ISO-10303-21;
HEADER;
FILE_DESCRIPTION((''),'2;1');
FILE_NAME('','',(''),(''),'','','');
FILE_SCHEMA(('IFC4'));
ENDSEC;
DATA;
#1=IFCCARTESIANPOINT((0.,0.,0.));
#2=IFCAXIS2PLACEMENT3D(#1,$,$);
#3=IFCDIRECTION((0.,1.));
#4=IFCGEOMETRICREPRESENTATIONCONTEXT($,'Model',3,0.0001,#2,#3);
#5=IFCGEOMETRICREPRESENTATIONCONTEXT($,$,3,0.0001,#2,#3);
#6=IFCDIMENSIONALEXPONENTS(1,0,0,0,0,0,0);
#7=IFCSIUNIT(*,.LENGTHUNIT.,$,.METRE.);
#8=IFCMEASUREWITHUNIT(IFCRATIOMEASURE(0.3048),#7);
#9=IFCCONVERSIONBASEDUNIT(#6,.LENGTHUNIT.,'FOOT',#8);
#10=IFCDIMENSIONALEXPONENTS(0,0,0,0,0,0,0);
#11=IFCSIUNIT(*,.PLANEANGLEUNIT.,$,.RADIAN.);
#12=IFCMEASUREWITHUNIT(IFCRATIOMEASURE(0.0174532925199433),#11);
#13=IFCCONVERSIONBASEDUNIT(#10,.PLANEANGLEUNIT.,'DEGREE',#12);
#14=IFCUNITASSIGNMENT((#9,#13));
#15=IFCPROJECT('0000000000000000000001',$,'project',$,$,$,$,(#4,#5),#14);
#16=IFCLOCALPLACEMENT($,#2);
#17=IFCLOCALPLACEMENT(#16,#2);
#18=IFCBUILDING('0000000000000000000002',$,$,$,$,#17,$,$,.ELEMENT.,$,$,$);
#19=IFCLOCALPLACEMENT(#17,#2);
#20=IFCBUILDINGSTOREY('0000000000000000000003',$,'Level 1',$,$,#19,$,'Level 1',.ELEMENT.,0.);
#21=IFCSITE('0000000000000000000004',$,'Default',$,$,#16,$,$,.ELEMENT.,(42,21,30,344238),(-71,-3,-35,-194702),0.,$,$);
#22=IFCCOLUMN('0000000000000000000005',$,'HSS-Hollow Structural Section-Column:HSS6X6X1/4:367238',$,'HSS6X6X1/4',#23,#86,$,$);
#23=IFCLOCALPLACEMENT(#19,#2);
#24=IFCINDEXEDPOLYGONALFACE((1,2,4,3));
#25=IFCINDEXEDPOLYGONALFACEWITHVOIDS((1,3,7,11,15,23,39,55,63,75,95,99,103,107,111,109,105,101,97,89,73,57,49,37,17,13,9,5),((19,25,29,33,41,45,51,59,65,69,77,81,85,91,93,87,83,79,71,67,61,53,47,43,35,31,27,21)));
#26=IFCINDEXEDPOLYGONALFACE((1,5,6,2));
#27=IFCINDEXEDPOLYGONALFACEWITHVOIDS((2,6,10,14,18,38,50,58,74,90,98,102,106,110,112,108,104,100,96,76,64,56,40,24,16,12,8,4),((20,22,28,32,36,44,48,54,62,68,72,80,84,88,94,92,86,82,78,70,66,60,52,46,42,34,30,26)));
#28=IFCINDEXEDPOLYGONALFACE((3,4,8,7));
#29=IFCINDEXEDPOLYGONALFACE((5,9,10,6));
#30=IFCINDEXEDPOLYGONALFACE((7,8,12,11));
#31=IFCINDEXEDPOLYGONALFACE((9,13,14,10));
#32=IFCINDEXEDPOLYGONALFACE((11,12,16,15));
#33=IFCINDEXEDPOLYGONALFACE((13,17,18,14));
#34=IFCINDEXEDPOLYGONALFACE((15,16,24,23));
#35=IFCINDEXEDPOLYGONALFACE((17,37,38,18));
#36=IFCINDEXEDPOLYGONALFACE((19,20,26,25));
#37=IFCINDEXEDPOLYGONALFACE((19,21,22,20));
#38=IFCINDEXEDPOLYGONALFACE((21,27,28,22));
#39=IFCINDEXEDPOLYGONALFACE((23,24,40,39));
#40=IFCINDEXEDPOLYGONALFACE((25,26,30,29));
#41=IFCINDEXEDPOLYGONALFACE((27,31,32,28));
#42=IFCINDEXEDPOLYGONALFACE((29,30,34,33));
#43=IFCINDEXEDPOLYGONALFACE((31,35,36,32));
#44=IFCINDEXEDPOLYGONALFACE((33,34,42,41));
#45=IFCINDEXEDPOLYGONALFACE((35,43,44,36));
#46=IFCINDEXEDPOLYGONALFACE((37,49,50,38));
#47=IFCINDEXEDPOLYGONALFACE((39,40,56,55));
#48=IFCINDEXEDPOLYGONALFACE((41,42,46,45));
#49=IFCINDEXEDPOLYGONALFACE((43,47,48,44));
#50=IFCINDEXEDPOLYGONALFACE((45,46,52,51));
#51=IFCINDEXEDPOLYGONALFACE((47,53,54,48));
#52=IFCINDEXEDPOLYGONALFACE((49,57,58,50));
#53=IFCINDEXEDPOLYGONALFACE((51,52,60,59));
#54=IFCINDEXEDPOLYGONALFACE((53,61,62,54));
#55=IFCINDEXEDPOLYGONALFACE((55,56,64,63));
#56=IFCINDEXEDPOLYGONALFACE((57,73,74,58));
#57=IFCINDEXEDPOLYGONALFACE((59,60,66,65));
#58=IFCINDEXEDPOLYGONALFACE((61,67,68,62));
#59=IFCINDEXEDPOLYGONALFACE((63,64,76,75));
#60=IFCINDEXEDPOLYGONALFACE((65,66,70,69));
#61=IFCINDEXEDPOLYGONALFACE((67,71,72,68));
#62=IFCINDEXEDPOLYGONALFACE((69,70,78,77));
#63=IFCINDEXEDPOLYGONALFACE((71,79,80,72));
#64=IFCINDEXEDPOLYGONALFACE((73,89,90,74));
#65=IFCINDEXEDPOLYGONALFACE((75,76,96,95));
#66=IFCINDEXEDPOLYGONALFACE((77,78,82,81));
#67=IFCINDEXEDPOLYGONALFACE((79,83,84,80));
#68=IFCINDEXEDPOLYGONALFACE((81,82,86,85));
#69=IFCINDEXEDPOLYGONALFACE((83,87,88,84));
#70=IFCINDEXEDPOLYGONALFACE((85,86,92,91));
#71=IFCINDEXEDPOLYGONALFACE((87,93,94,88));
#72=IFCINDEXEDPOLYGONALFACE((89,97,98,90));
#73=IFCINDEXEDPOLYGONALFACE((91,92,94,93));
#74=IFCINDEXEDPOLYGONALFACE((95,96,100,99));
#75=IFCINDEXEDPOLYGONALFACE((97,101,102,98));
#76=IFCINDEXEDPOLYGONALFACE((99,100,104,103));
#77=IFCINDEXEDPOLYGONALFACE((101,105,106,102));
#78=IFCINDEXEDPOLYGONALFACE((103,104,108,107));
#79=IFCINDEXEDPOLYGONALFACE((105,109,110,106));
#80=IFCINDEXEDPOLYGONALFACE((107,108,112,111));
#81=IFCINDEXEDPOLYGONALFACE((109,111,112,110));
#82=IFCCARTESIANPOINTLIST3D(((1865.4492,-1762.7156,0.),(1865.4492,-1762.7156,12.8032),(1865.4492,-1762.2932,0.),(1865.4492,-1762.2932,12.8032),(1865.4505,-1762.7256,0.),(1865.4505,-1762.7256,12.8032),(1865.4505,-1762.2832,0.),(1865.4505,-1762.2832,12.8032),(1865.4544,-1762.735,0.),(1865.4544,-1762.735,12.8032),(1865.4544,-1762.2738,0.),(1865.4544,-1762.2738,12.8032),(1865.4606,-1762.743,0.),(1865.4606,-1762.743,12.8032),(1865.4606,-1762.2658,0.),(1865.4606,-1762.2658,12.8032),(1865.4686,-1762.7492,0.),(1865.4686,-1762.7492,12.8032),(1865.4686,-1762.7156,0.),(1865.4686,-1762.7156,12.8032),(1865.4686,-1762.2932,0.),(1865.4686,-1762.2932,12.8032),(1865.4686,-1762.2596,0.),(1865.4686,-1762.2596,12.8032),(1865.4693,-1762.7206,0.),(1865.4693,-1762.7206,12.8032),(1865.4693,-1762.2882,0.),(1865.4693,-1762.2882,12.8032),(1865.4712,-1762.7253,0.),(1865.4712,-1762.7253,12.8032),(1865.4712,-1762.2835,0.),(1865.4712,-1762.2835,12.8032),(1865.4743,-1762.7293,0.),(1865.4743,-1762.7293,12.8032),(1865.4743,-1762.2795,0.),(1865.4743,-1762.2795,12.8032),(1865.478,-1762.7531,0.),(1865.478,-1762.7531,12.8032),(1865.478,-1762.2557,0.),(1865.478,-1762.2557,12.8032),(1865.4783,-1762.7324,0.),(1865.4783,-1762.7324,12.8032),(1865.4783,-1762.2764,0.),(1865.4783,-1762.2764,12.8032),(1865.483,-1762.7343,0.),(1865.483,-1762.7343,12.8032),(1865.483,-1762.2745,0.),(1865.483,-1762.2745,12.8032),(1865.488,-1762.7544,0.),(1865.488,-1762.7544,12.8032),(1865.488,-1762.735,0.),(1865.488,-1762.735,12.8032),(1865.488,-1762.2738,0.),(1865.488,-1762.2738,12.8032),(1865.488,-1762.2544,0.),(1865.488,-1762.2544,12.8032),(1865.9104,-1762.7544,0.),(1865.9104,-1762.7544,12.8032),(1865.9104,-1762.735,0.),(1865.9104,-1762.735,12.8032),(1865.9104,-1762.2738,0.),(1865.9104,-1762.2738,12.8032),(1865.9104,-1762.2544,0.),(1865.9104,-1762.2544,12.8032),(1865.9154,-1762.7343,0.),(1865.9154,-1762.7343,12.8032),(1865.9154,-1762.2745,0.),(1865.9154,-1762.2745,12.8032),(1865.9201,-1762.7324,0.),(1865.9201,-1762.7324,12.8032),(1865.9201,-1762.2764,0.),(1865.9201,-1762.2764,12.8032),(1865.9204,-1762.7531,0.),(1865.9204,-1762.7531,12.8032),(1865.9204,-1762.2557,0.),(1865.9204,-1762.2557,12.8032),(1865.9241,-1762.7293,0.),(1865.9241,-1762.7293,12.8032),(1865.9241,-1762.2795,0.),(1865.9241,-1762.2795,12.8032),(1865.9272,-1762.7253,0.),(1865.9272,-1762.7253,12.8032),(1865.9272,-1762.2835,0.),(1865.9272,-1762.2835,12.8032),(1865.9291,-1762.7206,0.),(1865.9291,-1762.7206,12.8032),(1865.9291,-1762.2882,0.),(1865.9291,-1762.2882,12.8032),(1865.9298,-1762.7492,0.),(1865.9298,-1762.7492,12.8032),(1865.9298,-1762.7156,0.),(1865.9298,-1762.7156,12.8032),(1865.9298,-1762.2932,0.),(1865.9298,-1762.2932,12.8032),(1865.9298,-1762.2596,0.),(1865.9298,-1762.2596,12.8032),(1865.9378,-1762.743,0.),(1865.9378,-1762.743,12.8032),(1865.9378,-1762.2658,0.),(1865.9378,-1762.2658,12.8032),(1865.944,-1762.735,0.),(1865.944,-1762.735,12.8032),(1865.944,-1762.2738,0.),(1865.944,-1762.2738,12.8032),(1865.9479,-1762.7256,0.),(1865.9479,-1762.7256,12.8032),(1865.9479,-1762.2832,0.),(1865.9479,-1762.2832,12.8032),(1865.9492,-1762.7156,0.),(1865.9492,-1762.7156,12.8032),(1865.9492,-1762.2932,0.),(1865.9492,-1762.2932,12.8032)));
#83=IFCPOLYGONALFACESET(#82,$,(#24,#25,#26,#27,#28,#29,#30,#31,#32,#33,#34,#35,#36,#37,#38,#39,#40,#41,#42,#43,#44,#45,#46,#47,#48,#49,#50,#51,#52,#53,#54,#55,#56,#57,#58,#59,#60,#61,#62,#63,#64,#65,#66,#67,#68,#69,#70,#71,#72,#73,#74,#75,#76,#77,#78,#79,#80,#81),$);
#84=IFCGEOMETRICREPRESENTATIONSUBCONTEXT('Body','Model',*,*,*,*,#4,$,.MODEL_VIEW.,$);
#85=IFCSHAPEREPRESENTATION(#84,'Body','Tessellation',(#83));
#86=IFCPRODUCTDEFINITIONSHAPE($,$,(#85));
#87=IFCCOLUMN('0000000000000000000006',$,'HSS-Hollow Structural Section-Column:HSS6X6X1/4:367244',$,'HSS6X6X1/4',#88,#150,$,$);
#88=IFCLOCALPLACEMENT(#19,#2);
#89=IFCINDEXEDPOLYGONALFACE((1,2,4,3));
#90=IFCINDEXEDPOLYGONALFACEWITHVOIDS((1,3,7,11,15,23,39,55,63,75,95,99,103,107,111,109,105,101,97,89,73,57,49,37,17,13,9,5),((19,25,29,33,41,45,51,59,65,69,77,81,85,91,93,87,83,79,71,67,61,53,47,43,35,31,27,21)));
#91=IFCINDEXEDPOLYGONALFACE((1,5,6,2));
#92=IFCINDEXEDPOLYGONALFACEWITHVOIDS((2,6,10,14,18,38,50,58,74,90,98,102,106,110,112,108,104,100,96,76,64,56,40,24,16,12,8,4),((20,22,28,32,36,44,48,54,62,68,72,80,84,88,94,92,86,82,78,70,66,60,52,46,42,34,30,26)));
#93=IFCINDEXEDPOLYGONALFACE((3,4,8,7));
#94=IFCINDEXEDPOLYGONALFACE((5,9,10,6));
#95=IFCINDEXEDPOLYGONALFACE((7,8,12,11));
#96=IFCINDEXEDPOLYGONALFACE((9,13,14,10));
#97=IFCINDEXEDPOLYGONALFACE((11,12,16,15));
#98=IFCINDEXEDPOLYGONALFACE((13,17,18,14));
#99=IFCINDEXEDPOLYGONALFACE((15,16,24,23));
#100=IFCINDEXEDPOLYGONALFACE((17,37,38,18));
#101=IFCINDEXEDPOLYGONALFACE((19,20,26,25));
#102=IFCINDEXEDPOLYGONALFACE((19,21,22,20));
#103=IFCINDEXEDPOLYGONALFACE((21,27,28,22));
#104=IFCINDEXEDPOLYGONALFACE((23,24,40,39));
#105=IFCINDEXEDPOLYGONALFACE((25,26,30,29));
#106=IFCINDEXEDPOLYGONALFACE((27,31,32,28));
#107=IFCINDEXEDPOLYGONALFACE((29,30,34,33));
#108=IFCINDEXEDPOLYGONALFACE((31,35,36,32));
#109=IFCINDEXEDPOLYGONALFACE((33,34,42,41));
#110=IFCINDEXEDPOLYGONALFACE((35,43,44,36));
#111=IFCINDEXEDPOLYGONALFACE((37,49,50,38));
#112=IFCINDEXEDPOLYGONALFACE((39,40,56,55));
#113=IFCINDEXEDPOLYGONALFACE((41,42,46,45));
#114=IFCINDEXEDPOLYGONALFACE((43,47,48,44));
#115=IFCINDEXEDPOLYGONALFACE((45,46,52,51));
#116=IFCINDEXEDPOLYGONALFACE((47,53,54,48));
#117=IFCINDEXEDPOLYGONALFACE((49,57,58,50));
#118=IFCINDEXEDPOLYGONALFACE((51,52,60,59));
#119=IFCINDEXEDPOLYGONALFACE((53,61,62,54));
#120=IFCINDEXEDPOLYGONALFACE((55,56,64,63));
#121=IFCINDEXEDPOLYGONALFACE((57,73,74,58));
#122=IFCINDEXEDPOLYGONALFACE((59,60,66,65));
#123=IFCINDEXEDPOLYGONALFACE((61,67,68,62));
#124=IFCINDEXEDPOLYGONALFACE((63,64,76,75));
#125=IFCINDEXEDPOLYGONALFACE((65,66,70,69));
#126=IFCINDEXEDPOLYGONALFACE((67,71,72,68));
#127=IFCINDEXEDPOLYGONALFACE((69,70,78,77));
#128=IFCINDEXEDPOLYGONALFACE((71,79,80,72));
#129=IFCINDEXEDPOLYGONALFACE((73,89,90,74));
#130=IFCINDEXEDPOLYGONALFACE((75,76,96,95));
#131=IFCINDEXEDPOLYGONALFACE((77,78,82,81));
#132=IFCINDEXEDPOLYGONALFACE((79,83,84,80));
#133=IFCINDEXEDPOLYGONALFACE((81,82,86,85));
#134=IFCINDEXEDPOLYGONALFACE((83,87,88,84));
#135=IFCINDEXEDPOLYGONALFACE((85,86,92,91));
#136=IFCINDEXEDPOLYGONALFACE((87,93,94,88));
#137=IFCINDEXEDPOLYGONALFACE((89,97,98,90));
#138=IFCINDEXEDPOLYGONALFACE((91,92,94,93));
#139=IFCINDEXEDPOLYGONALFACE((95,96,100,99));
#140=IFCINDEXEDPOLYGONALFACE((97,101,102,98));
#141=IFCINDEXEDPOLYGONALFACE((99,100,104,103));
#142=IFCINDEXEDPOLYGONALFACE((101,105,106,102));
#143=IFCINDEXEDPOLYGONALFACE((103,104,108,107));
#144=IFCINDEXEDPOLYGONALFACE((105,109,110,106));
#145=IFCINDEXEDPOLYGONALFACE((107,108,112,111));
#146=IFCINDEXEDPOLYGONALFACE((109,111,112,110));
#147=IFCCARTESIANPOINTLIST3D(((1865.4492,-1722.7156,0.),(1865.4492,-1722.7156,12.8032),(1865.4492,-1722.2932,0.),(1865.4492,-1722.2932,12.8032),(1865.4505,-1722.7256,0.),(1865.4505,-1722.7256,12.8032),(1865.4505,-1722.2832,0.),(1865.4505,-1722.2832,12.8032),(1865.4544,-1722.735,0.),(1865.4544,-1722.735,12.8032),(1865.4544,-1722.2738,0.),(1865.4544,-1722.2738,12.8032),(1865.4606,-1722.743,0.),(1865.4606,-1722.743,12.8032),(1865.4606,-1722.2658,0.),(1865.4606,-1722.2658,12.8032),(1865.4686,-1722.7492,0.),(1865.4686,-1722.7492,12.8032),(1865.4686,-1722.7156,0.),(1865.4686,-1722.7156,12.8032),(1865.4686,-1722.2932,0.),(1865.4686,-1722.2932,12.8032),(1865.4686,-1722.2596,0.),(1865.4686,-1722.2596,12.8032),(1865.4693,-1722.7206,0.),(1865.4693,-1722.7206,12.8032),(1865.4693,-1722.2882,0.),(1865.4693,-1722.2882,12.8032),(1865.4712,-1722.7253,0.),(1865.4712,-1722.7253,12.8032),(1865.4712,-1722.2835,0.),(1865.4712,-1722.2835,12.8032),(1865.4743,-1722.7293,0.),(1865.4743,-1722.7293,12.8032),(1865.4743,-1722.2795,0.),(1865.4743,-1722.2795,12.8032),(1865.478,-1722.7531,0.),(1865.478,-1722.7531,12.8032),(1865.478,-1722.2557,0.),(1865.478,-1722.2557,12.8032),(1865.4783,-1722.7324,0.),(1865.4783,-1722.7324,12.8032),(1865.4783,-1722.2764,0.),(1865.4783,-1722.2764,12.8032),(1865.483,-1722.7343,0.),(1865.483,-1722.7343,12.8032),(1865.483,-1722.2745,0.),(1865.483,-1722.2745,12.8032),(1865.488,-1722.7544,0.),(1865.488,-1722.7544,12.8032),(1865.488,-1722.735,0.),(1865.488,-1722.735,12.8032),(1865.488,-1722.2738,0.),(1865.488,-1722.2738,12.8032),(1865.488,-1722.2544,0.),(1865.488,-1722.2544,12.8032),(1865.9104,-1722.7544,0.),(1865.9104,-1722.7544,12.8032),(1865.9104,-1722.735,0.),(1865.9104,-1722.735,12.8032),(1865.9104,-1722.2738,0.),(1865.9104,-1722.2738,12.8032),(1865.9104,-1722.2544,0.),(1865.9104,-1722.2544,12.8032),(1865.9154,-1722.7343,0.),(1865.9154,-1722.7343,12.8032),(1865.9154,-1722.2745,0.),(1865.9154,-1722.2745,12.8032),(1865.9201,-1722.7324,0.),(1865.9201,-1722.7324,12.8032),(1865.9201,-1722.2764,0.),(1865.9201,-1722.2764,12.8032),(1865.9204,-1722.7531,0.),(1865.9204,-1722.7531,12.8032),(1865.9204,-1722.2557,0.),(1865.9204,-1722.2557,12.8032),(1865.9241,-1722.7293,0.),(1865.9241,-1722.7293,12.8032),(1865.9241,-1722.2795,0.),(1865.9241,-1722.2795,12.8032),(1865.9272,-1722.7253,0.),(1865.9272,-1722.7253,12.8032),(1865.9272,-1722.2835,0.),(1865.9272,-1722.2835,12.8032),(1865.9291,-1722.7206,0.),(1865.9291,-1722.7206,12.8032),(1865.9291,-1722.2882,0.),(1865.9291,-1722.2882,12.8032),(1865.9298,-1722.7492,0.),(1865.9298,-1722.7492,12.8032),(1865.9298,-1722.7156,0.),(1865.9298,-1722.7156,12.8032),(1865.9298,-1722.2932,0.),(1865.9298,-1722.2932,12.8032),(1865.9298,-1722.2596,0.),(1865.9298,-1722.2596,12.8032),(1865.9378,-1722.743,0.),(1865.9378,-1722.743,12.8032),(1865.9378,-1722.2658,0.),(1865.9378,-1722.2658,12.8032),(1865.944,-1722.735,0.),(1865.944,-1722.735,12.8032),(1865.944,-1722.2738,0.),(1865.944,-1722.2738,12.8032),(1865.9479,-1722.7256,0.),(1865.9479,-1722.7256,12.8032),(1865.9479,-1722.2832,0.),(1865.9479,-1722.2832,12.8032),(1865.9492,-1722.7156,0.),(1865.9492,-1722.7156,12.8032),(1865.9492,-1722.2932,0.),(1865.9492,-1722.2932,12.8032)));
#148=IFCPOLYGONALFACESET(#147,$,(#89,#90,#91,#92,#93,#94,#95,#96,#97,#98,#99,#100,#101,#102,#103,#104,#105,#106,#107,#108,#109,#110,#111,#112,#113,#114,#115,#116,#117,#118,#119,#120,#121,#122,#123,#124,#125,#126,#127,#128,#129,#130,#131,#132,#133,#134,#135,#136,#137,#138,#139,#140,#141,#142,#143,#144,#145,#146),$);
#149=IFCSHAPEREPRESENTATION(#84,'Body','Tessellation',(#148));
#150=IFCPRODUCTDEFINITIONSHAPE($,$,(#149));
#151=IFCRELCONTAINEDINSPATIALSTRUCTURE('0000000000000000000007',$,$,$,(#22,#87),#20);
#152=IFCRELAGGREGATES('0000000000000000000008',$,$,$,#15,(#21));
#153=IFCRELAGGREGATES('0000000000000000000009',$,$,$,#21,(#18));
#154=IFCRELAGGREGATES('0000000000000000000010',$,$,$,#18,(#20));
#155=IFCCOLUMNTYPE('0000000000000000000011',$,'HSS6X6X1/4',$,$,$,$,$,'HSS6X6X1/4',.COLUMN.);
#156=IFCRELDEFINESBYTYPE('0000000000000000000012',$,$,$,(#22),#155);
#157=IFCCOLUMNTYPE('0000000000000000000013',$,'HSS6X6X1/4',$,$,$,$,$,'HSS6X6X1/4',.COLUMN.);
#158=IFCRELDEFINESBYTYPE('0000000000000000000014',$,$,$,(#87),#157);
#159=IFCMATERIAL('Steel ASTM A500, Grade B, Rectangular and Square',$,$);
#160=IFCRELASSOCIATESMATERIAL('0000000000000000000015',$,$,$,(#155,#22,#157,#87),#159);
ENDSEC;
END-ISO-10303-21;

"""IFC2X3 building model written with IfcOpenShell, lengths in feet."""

from ifc_helpers import new_model, entity, si_unit, converted_unit, direction, frame, frame_2d, origin, place, context, subcontext, project, spatial, polyline, circle_curve, parameter, trimmed, segment, composite_curve, outline, extrude, source, transform, mapped, material, type_object, type_shapes, element, save


model = new_model("IFC2X3")

# Units and contexts
model_context = context("Model", 3, precision=0.0001, world=origin(), true_north=direction((0.0, 1.0)))
context_of_model = context(None, 3, precision=0.0001, world=origin(), true_north=direction((0.0, 1.0)))
body_context = subcontext(model_context, "Body", "Model", "MODEL_VIEW")
ifc_project = project(units=[converted_unit("LENGTHUNIT", "FOOT", entity("IfcRatioMeasure", 0.3048), si_unit("LENGTHUNIT", "METRE"), dimensions=[1, 0, 0, 0, 0, 0, 0]), converted_unit("PLANEANGLEUNIT", "DEGREE", entity("IfcRatioMeasure", 0.0174532925199433), si_unit("PLANEANGLEUNIT", "RADIAN"), dimensions=[0, 0, 0, 0, 0, 0, 0])], contexts=[model_context, context_of_model])

# Site, building, storey
site_placement = place(None, origin())
site = spatial("IfcSite", under=ifc_project, at=site_placement, Name="Default", CompositionType="ELEMENT", RefLatitude=(42, 21, 30, 344238), RefLongitude=(-71, -3, -35, -194702), RefElevation=0.0)
building_placement = place(site_placement, origin())
building = spatial("IfcBuilding", under=site, at=building_placement, CompositionType="ELEMENT")
storey_placement = place(building_placement, origin())
storey = spatial("IfcBuildingStorey", under=building, at=storey_placement, Name="Level 1", LongName="Level 1", CompositionType="ELEMENT", Elevation=0.0)

# Columns
ifc_material_1 = material(Name="Steel ASTM A500, Grade B, Rectangular and Square")
column_type_1 = type_object("IfcColumnType", Name="HSS6X6X1/4", ElementType="HSS6X6X1/4", PredefinedType="COLUMN", material=ifc_material_1)
shared_shape_1 = source(origin(), body_context, "Body", "SweptSolid", [
    extrude(outline(composite_curve([segment(polyline([(-0.2112, -0.25), (0.2112, -0.25)]), True, "CONTINUOUS"), segment(trimmed(circle_curve(frame_2d((0.2112, -0.2112), x_axis=(-1.0, 0.0)), 0.0388), [parameter(90.0)], [parameter(180.0)], True, "PARAMETER"), True, "CONTINUOUS"), segment(polyline([(0.25, -0.2112), (0.25, 0.2112)]), True, "CONTINUOUS"), segment(trimmed(circle_curve(frame_2d((0.2112, 0.2112), x_axis=(-1.0, 0.0)), 0.0388), [parameter(180.0)], [parameter(270.0)], True, "PARAMETER"), True, "CONTINUOUS"), segment(polyline([(0.2112, 0.25), (-0.2112, 0.25)]), True, "CONTINUOUS"), segment(trimmed(circle_curve(frame_2d((-0.2112, 0.2112), x_axis=(-1.0, 0.0)), 0.0388), [parameter(270.0)], [parameter(360.0)], True, "PARAMETER"), True, "CONTINUOUS"), segment(polyline([(-0.25, 0.2112), (-0.25, -0.2112)]), True, "CONTINUOUS"), segment(trimmed(circle_curve(frame_2d((-0.2112, -0.2112), x_axis=(-1.0, 0.0)), 0.0388), [parameter(360.0)], [parameter(90.0)], True, "PARAMETER"), True, "CONTINUOUS")], self_intersect=False), holes=[composite_curve([segment(trimmed(circle_curve(frame_2d((-0.2112, -0.2112), x_axis=(-1.0, 0.0)), 0.0194), [parameter(0.0)], [parameter(90.0)], True, "PARAMETER"), False, "CONTINUOUS"), segment(polyline([(-0.2306, -0.2112), (-0.2306, 0.2112)]), True, "CONTINUOUS"), segment(trimmed(circle_curve(frame_2d((-0.2112, 0.2112), x_axis=(-1.0, 0.0)), 0.0194), [parameter(270.0)], [parameter(360.0)], True, "PARAMETER"), False, "CONTINUOUS"), segment(polyline([(-0.2112, 0.2306), (0.2112, 0.2306)]), True, "CONTINUOUS"), segment(trimmed(circle_curve(frame_2d((0.2112, 0.2112), x_axis=(-1.0, 0.0)), 0.0194), [parameter(180.0)], [parameter(270.0)], True, "PARAMETER"), False, "CONTINUOUS"), segment(polyline([(0.2306, 0.2112), (0.2306, -0.2112)]), True, "CONTINUOUS"), segment(trimmed(circle_curve(frame_2d((0.2112, -0.2112), x_axis=(-1.0, 0.0)), 0.0194), [parameter(90.0)], [parameter(180.0)], True, "PARAMETER"), False, "CONTINUOUS"), segment(polyline([(0.2112, -0.2306), (-0.2112, -0.2306)]), True, "CONTINUOUS")], self_intersect=False)]), frame((1865.6992, -1762.5044, 0.0)), (0.0, 0.0, 1.0), 12.8032),
])
type_shapes(column_type_1, [shared_shape_1])
column_1_placement = place(storey_placement, origin())
element("IfcColumn", 1, at=column_1_placement, inside=storey, type_object=column_type_1, material=ifc_material_1, Name="HSS-Hollow Structural Section-Column:HSS6X6X1/4:367238", ObjectType="HSS6X6X1/4", context=body_context, shape_type="MappedRepresentation", body=[
    mapped(shared_shape_1, transform((0.0, 0.0, 0.0), scale=1.0)),
])
column_type_2 = type_object("IfcColumnType", Name="HSS6X6X1/4", ElementType="HSS6X6X1/4", PredefinedType="COLUMN", material=ifc_material_1)
shared_shape_2 = source(origin(), body_context, "Body", "SweptSolid", [
    extrude(outline(composite_curve([segment(polyline([(-0.2112, -0.25), (0.2112, -0.25)]), True, "CONTINUOUS"), segment(trimmed(circle_curve(frame_2d((0.2112, -0.2112), x_axis=(-1.0, 0.0)), 0.0388), [parameter(90.0)], [parameter(180.0)], True, "PARAMETER"), True, "CONTINUOUS"), segment(polyline([(0.25, -0.2112), (0.25, 0.2112)]), True, "CONTINUOUS"), segment(trimmed(circle_curve(frame_2d((0.2112, 0.2112), x_axis=(-1.0, 0.0)), 0.0388), [parameter(180.0)], [parameter(270.0)], True, "PARAMETER"), True, "CONTINUOUS"), segment(polyline([(0.2112, 0.25), (-0.2112, 0.25)]), True, "CONTINUOUS"), segment(trimmed(circle_curve(frame_2d((-0.2112, 0.2112), x_axis=(-1.0, 0.0)), 0.0388), [parameter(270.0)], [parameter(360.0)], True, "PARAMETER"), True, "CONTINUOUS"), segment(polyline([(-0.25, 0.2112), (-0.25, -0.2112)]), True, "CONTINUOUS"), segment(trimmed(circle_curve(frame_2d((-0.2112, -0.2112), x_axis=(-1.0, 0.0)), 0.0388), [parameter(360.0)], [parameter(90.0)], True, "PARAMETER"), True, "CONTINUOUS")], self_intersect=False), holes=[composite_curve([segment(trimmed(circle_curve(frame_2d((-0.2112, -0.2112), x_axis=(-1.0, 0.0)), 0.0194), [parameter(0.0)], [parameter(90.0)], True, "PARAMETER"), False, "CONTINUOUS"), segment(polyline([(-0.2306, -0.2112), (-0.2306, 0.2112)]), True, "CONTINUOUS"), segment(trimmed(circle_curve(frame_2d((-0.2112, 0.2112), x_axis=(-1.0, 0.0)), 0.0194), [parameter(270.0)], [parameter(360.0)], True, "PARAMETER"), False, "CONTINUOUS"), segment(polyline([(-0.2112, 0.2306), (0.2112, 0.2306)]), True, "CONTINUOUS"), segment(trimmed(circle_curve(frame_2d((0.2112, 0.2112), x_axis=(-1.0, 0.0)), 0.0194), [parameter(180.0)], [parameter(270.0)], True, "PARAMETER"), False, "CONTINUOUS"), segment(polyline([(0.2306, 0.2112), (0.2306, -0.2112)]), True, "CONTINUOUS"), segment(trimmed(circle_curve(frame_2d((0.2112, -0.2112), x_axis=(-1.0, 0.0)), 0.0194), [parameter(90.0)], [parameter(180.0)], True, "PARAMETER"), False, "CONTINUOUS"), segment(polyline([(0.2112, -0.2306), (-0.2112, -0.2306)]), True, "CONTINUOUS")], self_intersect=False)]), frame((1865.6992, -1722.5044, 0.0)), (0.0, 0.0, 1.0), 12.8032),
])
type_shapes(column_type_2, [shared_shape_2])
column_2_placement = place(storey_placement, origin())
element("IfcColumn", 2, at=column_2_placement, inside=storey, type_object=column_type_2, material=ifc_material_1, Name="HSS-Hollow Structural Section-Column:HSS6X6X1/4:367244", ObjectType="HSS6X6X1/4", context=body_context, shape_type="MappedRepresentation", body=[
    mapped(shared_shape_2, transform((0.0, 0.0, 0.0), scale=1.0)),
])

save(model, "model.ifc")
